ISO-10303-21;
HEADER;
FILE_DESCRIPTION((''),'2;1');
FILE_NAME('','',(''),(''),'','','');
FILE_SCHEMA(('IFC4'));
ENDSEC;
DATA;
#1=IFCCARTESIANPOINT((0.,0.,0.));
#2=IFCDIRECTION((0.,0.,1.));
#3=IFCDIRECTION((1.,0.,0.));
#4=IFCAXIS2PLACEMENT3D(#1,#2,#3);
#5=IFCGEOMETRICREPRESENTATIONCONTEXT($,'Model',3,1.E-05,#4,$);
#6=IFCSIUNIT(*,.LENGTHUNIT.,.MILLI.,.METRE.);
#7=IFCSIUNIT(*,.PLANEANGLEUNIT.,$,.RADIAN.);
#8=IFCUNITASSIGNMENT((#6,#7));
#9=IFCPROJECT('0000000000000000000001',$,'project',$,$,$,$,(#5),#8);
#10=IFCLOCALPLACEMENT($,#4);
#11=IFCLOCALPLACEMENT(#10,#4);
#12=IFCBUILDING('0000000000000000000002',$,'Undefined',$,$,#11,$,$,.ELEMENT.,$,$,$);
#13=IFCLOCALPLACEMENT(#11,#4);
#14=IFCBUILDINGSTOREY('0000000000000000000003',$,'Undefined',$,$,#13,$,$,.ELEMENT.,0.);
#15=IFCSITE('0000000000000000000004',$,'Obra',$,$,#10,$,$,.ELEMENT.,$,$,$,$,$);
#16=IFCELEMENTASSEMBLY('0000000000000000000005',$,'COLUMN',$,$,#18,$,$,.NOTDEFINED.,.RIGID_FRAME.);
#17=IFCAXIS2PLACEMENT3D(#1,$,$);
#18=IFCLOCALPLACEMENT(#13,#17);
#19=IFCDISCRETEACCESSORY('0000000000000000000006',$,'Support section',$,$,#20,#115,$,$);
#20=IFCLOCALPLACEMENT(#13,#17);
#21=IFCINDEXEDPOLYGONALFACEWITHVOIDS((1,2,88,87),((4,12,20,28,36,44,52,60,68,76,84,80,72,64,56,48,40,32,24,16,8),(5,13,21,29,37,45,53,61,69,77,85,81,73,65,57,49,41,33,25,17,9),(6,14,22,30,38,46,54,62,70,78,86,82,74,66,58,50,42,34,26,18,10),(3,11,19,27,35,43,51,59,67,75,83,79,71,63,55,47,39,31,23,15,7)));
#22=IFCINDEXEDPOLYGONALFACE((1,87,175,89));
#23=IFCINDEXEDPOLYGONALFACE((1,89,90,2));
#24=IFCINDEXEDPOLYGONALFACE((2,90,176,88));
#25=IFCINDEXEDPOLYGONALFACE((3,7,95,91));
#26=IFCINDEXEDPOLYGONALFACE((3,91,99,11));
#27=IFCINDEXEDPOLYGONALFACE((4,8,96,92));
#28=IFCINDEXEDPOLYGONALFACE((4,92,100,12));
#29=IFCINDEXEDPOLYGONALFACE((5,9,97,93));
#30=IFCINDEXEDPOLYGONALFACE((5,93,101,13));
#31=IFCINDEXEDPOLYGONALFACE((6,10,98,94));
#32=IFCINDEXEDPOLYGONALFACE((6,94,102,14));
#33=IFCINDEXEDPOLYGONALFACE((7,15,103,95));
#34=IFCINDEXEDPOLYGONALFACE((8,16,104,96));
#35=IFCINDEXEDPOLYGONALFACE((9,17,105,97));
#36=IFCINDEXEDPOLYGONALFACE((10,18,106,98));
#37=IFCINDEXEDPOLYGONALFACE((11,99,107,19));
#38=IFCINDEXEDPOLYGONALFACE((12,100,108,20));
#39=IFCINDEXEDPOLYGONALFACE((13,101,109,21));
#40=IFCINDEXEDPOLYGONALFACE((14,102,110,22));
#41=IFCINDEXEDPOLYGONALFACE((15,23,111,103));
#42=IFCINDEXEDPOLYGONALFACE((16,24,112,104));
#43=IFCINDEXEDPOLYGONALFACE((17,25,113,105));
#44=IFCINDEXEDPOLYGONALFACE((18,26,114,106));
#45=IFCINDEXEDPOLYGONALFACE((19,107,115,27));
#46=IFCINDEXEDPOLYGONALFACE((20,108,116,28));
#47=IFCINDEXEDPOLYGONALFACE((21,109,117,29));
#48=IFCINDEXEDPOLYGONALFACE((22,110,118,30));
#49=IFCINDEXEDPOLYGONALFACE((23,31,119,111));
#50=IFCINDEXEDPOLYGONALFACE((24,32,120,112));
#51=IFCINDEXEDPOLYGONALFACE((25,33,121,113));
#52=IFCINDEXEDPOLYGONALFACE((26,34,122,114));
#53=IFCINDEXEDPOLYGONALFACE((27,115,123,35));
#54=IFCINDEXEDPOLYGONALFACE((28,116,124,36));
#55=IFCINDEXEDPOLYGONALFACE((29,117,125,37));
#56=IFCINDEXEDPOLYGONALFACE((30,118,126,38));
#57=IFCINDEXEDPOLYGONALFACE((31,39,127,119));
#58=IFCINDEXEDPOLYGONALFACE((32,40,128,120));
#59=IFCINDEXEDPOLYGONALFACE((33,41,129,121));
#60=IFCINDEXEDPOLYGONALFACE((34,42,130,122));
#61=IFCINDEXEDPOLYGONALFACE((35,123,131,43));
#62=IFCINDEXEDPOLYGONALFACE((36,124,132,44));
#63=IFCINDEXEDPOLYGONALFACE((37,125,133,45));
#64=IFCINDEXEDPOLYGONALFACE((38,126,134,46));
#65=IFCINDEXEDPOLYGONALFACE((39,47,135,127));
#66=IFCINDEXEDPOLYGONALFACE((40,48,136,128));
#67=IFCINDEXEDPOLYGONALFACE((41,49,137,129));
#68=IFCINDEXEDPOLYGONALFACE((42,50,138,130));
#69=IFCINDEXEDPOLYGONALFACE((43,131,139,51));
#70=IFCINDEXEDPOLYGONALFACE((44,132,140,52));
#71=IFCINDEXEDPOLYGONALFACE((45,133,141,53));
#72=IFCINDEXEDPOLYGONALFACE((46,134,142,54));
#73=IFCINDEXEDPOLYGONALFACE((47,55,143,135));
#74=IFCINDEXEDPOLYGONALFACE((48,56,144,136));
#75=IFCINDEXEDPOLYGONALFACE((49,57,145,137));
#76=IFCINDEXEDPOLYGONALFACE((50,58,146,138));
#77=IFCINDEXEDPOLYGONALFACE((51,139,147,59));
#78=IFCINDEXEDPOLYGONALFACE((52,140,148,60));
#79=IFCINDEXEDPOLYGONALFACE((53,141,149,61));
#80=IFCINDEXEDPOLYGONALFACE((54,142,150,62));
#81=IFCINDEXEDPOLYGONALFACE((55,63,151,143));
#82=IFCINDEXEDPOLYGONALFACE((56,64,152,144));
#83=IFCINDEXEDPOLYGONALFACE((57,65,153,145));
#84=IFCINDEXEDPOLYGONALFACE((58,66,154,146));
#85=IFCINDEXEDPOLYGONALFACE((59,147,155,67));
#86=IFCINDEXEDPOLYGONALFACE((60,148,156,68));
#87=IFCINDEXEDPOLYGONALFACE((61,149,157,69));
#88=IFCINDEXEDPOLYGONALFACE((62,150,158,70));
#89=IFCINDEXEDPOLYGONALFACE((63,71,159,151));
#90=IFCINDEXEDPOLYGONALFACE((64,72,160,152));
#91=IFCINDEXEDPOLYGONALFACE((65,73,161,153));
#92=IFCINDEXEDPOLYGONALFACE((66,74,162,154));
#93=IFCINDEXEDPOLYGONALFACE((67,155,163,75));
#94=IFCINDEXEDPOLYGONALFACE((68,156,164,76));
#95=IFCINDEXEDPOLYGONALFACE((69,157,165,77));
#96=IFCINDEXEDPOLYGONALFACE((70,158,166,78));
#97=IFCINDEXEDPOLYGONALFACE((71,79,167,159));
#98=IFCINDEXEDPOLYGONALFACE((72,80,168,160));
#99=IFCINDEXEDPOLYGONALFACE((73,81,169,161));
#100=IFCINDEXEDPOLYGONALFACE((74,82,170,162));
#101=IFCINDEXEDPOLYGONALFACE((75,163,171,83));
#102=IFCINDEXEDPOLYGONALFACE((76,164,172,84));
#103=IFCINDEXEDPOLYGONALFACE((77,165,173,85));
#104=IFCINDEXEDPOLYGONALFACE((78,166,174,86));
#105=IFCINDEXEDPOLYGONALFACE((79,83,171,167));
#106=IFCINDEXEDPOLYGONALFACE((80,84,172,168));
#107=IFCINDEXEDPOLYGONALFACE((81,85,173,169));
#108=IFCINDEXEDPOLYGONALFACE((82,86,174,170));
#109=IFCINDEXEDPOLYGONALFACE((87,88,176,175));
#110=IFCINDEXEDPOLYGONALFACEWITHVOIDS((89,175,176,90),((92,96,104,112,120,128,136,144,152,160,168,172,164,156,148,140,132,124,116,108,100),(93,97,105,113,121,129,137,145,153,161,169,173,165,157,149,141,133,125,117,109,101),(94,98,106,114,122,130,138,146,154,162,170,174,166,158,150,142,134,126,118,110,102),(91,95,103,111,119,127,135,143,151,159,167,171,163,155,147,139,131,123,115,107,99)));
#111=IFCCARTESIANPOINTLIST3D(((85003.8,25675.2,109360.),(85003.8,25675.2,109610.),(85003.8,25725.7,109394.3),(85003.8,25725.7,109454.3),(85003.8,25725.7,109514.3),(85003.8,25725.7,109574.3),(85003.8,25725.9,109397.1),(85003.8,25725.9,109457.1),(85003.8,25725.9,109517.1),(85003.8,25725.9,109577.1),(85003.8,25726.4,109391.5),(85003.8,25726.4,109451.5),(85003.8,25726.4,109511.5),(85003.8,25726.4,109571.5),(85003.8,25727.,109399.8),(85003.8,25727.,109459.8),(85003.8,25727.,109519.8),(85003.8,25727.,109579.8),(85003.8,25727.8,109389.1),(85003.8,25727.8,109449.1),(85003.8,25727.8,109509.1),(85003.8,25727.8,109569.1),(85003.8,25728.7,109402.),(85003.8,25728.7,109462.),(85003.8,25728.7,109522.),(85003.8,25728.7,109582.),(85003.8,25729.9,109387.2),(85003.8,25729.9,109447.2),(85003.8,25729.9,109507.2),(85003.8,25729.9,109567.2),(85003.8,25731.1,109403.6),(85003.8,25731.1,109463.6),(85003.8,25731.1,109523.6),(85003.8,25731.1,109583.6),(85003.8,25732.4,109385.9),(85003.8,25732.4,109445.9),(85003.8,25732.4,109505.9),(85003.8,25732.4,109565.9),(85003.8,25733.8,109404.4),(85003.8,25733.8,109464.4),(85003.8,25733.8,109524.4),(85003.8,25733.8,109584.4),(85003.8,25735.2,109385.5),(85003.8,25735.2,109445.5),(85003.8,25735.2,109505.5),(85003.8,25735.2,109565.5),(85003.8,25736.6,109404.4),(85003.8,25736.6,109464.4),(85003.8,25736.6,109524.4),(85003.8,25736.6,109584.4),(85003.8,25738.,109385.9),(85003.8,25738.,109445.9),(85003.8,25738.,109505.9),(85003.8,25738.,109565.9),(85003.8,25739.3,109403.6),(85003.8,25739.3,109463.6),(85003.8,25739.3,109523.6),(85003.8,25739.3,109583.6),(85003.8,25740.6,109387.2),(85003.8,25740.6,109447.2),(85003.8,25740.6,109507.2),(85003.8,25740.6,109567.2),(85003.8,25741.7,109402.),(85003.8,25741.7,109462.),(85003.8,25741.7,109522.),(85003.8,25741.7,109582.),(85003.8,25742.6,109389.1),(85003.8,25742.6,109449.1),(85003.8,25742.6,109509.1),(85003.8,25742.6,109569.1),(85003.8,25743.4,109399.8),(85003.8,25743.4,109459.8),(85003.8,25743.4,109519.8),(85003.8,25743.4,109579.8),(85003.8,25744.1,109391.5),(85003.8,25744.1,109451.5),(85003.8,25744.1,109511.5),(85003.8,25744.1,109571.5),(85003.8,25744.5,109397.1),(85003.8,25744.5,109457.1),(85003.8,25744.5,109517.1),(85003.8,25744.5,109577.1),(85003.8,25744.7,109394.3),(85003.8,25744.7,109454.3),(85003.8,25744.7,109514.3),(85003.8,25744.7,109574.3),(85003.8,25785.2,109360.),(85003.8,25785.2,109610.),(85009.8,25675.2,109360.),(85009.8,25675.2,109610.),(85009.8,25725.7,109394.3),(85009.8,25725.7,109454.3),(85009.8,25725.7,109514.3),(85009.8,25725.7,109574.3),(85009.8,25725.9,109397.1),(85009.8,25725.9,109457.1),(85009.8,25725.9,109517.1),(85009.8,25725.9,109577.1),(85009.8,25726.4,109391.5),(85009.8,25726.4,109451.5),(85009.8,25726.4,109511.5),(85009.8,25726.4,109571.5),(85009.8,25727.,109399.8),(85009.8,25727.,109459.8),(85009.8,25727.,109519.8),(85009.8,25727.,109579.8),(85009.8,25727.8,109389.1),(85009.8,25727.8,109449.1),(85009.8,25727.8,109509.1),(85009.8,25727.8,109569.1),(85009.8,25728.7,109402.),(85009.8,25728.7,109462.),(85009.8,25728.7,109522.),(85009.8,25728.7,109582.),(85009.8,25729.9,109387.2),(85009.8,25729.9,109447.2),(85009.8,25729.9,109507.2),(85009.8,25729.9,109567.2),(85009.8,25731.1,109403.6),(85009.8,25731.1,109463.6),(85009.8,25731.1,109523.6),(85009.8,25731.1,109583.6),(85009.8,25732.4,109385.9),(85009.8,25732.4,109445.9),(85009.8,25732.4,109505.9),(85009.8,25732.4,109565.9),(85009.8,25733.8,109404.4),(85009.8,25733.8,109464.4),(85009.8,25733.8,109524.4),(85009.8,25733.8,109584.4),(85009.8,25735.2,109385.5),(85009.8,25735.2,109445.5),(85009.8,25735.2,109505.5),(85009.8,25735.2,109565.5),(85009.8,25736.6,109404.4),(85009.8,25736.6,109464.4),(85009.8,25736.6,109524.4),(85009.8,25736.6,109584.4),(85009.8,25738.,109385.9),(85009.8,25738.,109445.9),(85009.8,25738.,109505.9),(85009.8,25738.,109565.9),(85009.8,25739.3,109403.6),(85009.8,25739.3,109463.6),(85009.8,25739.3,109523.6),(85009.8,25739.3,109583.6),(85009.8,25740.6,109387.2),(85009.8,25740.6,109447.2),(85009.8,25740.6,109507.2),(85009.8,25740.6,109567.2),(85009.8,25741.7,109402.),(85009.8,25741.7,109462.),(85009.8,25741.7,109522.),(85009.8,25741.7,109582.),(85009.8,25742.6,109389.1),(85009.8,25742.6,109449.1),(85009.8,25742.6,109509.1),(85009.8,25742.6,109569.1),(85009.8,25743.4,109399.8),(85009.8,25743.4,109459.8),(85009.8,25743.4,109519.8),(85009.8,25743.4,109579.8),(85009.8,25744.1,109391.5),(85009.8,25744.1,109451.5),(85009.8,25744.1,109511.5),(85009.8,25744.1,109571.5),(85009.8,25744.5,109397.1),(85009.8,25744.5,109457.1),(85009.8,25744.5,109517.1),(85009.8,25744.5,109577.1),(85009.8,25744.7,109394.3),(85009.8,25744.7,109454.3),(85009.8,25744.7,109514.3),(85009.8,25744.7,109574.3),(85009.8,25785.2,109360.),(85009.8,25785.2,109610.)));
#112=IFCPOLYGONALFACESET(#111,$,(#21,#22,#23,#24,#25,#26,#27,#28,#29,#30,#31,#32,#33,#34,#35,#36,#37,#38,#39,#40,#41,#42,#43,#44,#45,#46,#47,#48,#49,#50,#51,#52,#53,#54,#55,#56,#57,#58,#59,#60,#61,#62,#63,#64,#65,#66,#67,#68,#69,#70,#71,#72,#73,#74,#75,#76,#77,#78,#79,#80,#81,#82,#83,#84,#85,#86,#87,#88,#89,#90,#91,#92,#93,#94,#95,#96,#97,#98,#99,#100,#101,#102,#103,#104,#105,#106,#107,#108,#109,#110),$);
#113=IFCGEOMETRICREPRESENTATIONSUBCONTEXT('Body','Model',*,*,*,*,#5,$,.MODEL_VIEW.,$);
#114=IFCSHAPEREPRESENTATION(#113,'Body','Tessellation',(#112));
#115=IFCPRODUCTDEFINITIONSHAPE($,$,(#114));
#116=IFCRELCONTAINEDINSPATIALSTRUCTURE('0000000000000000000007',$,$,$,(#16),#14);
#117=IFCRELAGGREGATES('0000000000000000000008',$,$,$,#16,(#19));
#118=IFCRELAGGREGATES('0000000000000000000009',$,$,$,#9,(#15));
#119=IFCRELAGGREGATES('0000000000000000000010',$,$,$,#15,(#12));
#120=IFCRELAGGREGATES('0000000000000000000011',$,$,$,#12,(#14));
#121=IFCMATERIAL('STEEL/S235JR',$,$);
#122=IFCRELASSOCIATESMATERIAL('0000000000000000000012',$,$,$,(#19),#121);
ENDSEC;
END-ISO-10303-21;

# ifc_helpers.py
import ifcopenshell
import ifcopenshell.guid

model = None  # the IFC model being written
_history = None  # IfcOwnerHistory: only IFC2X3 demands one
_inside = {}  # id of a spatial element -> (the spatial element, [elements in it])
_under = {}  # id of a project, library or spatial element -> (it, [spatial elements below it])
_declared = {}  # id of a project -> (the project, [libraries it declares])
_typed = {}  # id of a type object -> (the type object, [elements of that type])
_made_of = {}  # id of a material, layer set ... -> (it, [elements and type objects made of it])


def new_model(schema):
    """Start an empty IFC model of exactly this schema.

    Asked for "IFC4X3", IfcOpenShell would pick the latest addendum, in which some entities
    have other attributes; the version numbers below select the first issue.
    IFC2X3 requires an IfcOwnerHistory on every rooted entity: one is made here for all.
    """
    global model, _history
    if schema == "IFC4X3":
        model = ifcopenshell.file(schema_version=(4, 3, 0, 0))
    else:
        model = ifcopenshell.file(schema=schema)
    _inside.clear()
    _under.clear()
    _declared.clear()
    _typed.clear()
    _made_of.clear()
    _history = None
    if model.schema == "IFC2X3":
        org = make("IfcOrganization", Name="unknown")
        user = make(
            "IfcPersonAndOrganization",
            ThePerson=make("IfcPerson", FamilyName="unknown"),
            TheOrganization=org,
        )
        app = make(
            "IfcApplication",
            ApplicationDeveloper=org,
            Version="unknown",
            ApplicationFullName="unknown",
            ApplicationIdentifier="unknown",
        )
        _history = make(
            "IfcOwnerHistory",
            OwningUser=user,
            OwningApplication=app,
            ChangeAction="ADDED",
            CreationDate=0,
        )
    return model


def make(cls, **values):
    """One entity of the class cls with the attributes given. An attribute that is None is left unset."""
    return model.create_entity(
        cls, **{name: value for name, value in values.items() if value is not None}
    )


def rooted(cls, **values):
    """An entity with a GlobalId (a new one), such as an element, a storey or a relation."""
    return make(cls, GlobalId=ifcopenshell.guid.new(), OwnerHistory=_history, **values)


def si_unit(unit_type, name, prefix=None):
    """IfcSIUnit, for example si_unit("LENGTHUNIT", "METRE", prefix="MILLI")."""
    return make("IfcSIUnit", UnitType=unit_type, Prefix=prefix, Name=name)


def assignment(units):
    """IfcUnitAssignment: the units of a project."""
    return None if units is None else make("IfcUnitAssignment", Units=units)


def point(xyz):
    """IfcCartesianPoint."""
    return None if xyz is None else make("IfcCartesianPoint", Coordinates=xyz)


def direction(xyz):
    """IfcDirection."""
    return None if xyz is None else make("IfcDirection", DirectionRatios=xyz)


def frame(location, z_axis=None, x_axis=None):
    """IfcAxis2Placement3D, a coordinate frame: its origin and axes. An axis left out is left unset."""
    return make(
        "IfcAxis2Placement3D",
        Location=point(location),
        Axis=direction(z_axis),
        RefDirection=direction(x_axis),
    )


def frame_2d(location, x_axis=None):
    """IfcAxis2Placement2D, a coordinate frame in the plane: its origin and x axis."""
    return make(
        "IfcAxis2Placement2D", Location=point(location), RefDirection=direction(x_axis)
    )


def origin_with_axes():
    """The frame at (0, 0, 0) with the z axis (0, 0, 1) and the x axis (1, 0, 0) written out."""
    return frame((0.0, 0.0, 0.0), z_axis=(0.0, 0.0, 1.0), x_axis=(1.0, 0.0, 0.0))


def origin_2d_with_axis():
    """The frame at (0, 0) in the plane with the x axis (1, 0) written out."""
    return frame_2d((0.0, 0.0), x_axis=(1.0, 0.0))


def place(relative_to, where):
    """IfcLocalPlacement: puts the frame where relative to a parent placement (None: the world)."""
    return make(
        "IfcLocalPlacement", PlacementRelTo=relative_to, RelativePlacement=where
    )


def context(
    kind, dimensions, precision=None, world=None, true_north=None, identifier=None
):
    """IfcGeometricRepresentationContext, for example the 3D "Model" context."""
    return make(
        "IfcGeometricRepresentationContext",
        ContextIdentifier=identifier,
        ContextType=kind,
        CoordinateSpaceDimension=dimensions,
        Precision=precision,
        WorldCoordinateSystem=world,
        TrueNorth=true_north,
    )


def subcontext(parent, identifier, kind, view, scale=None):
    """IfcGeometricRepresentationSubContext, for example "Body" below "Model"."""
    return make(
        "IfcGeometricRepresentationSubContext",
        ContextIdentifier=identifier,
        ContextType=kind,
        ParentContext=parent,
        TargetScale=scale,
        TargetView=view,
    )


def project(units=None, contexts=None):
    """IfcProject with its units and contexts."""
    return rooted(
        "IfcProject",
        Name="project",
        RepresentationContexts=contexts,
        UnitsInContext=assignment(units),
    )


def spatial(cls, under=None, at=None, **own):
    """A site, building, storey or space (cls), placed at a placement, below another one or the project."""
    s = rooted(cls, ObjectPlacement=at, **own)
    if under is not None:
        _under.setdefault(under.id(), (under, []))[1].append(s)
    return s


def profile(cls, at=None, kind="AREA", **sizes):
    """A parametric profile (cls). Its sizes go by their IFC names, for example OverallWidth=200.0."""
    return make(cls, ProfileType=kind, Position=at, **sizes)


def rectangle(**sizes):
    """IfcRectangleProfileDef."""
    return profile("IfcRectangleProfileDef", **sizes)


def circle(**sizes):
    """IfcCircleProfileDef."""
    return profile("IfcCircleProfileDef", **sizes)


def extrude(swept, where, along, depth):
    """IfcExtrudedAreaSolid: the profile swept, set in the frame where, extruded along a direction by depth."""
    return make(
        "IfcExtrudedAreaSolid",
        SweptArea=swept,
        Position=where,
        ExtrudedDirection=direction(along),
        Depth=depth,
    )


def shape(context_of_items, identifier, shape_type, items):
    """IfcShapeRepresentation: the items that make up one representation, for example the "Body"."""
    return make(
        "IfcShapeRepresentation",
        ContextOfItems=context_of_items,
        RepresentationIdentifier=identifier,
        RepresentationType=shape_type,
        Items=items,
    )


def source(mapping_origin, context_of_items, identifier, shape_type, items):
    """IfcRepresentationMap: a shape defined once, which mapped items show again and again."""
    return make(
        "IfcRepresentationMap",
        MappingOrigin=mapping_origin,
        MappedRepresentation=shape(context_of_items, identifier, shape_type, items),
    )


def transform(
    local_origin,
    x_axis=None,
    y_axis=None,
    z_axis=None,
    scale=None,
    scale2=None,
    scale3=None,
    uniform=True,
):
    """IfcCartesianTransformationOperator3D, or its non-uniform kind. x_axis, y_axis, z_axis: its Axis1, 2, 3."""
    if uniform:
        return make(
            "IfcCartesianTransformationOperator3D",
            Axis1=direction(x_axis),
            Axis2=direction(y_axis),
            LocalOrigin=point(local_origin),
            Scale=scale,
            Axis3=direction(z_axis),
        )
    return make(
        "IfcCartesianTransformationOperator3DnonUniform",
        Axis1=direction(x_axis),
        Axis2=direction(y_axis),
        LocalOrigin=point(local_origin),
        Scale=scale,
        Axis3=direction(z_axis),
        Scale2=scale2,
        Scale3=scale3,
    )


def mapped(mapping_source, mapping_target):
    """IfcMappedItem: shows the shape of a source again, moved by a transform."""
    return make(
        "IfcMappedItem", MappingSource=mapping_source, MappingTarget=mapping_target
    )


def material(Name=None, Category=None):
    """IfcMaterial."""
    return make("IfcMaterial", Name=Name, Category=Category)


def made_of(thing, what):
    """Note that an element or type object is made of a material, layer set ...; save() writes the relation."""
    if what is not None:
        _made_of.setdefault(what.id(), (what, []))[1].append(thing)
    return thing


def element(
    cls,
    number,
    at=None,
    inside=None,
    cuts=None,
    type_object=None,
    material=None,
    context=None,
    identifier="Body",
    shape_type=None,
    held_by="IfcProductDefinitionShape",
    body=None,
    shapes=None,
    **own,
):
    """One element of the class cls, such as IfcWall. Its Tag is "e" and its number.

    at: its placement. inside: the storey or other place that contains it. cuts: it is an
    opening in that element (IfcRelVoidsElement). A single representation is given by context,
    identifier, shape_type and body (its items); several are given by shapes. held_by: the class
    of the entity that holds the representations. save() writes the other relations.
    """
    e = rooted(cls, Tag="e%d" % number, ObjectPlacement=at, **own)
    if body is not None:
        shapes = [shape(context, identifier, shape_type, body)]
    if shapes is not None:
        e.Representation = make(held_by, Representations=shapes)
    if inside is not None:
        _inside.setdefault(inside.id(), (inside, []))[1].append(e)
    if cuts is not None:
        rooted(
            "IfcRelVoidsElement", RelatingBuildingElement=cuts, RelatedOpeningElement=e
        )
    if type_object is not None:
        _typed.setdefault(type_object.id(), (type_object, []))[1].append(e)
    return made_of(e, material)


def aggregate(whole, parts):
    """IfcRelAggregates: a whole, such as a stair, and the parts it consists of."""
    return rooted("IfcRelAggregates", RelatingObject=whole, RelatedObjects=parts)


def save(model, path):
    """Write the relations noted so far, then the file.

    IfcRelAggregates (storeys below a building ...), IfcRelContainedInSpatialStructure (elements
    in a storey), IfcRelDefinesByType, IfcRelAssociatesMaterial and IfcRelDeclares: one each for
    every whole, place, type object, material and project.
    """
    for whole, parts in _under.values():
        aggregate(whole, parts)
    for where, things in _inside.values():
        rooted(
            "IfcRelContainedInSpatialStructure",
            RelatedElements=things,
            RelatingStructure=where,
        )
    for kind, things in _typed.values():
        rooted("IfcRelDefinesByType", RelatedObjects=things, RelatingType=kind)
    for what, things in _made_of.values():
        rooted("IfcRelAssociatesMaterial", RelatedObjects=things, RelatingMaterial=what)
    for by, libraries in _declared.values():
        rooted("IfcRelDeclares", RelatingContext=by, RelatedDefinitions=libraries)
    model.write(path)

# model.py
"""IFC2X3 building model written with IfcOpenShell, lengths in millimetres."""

from ifc_helpers import new_model, si_unit, frame, origin_with_axes, origin_2d_with_axis, place, context, subcontext, project, spatial, rectangle, circle, extrude, source, transform, mapped, material, element, aggregate, save


model = new_model("IFC2X3")

# Units and contexts
model_context = context("Model", 3, precision=1e-05, world=origin_with_axes())
body_context = subcontext(model_context, "Body", "Model", "MODEL_VIEW")
ifc_project = project(units=[si_unit("LENGTHUNIT", "METRE", prefix="MILLI"), si_unit("PLANEANGLEUNIT", "RADIAN")], contexts=[model_context])

# Site, building, storey
site_placement = place(None, origin_with_axes())
site = spatial("IfcSite", under=ifc_project, at=site_placement, Name="Obra", CompositionType="ELEMENT")
building_placement = place(site_placement, origin_with_axes())
building = spatial("IfcBuilding", under=site, at=building_placement, Name="Undefined", CompositionType="ELEMENT")
storey_placement = place(building_placement, origin_with_axes())
storey = spatial("IfcBuildingStorey", under=building, at=storey_placement, Name="Undefined", CompositionType="ELEMENT", Elevation=0.0)

# Element assembly
ifc_material_1 = material(Name="STEEL/S235JR")
assembly_1_placement = place(storey_placement, origin_with_axes())
assembly_1 = element("IfcElementAssembly", 1, at=assembly_1_placement, inside=storey, Name="COLUMN", AssemblyPlace="NOTDEFINED", PredefinedType="RIGID_FRAME")

# Discrete accessory, opening
shared_shape_1 = source(origin_with_axes(), body_context, "Body", "SweptSolid", [
    extrude(circle(Radius=9.5, at=origin_2d_with_axis()), frame((0.0, -9.8, 0.0), z_axis=(0.0, 1.0, 0.0), x_axis=(1.0, 0.0, 0.0)), (0.0, 0.0, 1.0), 6.2),
])
discrete_accessory_1_placement = place(assembly_1_placement, frame((85006.8, 25730.2, 109360.0), z_axis=(0.0, 0.0, 1.0), x_axis=(0.0, -1.0, 0.0)))
discrete_accessory_1 = element("IfcDiscreteAccessory", 2, at=discrete_accessory_1_placement, material=ifc_material_1, Name="Support section", context=body_context, shape_type="SweptSolid", body=[
    extrude(rectangle(XDim=6.0, YDim=110.0, at=origin_2d_with_axis()), frame((0.0, 0.0, 250.0), z_axis=(0.0, 0.0, -1.0), x_axis=(0.0, 1.0, 0.0)), (0.0, 0.0, 1.0), 250.0),
])
opening_1_placement = place(assembly_1_placement, frame((85000.0, 25685.2, 109650.0), z_axis=(0.0, 1.0, 0.0), x_axis=(0.0, 0.0, -1.0)))
element("IfcOpeningElement", 3, at=opening_1_placement, cuts=discrete_accessory_1, ObjectType="Opening", context=body_context, shape_type="MappedRepresentation", body=[
    mapped(shared_shape_1, transform((75.0, 0.0, 50.0))),
    mapped(shared_shape_1, transform((135.0, 0.0, 50.0))),
    mapped(shared_shape_1, transform((195.0, 0.0, 50.0))),
    mapped(shared_shape_1, transform((255.0, 0.0, 50.0))),
])
aggregate(assembly_1, [discrete_accessory_1])

save(model, "model.ifc")
